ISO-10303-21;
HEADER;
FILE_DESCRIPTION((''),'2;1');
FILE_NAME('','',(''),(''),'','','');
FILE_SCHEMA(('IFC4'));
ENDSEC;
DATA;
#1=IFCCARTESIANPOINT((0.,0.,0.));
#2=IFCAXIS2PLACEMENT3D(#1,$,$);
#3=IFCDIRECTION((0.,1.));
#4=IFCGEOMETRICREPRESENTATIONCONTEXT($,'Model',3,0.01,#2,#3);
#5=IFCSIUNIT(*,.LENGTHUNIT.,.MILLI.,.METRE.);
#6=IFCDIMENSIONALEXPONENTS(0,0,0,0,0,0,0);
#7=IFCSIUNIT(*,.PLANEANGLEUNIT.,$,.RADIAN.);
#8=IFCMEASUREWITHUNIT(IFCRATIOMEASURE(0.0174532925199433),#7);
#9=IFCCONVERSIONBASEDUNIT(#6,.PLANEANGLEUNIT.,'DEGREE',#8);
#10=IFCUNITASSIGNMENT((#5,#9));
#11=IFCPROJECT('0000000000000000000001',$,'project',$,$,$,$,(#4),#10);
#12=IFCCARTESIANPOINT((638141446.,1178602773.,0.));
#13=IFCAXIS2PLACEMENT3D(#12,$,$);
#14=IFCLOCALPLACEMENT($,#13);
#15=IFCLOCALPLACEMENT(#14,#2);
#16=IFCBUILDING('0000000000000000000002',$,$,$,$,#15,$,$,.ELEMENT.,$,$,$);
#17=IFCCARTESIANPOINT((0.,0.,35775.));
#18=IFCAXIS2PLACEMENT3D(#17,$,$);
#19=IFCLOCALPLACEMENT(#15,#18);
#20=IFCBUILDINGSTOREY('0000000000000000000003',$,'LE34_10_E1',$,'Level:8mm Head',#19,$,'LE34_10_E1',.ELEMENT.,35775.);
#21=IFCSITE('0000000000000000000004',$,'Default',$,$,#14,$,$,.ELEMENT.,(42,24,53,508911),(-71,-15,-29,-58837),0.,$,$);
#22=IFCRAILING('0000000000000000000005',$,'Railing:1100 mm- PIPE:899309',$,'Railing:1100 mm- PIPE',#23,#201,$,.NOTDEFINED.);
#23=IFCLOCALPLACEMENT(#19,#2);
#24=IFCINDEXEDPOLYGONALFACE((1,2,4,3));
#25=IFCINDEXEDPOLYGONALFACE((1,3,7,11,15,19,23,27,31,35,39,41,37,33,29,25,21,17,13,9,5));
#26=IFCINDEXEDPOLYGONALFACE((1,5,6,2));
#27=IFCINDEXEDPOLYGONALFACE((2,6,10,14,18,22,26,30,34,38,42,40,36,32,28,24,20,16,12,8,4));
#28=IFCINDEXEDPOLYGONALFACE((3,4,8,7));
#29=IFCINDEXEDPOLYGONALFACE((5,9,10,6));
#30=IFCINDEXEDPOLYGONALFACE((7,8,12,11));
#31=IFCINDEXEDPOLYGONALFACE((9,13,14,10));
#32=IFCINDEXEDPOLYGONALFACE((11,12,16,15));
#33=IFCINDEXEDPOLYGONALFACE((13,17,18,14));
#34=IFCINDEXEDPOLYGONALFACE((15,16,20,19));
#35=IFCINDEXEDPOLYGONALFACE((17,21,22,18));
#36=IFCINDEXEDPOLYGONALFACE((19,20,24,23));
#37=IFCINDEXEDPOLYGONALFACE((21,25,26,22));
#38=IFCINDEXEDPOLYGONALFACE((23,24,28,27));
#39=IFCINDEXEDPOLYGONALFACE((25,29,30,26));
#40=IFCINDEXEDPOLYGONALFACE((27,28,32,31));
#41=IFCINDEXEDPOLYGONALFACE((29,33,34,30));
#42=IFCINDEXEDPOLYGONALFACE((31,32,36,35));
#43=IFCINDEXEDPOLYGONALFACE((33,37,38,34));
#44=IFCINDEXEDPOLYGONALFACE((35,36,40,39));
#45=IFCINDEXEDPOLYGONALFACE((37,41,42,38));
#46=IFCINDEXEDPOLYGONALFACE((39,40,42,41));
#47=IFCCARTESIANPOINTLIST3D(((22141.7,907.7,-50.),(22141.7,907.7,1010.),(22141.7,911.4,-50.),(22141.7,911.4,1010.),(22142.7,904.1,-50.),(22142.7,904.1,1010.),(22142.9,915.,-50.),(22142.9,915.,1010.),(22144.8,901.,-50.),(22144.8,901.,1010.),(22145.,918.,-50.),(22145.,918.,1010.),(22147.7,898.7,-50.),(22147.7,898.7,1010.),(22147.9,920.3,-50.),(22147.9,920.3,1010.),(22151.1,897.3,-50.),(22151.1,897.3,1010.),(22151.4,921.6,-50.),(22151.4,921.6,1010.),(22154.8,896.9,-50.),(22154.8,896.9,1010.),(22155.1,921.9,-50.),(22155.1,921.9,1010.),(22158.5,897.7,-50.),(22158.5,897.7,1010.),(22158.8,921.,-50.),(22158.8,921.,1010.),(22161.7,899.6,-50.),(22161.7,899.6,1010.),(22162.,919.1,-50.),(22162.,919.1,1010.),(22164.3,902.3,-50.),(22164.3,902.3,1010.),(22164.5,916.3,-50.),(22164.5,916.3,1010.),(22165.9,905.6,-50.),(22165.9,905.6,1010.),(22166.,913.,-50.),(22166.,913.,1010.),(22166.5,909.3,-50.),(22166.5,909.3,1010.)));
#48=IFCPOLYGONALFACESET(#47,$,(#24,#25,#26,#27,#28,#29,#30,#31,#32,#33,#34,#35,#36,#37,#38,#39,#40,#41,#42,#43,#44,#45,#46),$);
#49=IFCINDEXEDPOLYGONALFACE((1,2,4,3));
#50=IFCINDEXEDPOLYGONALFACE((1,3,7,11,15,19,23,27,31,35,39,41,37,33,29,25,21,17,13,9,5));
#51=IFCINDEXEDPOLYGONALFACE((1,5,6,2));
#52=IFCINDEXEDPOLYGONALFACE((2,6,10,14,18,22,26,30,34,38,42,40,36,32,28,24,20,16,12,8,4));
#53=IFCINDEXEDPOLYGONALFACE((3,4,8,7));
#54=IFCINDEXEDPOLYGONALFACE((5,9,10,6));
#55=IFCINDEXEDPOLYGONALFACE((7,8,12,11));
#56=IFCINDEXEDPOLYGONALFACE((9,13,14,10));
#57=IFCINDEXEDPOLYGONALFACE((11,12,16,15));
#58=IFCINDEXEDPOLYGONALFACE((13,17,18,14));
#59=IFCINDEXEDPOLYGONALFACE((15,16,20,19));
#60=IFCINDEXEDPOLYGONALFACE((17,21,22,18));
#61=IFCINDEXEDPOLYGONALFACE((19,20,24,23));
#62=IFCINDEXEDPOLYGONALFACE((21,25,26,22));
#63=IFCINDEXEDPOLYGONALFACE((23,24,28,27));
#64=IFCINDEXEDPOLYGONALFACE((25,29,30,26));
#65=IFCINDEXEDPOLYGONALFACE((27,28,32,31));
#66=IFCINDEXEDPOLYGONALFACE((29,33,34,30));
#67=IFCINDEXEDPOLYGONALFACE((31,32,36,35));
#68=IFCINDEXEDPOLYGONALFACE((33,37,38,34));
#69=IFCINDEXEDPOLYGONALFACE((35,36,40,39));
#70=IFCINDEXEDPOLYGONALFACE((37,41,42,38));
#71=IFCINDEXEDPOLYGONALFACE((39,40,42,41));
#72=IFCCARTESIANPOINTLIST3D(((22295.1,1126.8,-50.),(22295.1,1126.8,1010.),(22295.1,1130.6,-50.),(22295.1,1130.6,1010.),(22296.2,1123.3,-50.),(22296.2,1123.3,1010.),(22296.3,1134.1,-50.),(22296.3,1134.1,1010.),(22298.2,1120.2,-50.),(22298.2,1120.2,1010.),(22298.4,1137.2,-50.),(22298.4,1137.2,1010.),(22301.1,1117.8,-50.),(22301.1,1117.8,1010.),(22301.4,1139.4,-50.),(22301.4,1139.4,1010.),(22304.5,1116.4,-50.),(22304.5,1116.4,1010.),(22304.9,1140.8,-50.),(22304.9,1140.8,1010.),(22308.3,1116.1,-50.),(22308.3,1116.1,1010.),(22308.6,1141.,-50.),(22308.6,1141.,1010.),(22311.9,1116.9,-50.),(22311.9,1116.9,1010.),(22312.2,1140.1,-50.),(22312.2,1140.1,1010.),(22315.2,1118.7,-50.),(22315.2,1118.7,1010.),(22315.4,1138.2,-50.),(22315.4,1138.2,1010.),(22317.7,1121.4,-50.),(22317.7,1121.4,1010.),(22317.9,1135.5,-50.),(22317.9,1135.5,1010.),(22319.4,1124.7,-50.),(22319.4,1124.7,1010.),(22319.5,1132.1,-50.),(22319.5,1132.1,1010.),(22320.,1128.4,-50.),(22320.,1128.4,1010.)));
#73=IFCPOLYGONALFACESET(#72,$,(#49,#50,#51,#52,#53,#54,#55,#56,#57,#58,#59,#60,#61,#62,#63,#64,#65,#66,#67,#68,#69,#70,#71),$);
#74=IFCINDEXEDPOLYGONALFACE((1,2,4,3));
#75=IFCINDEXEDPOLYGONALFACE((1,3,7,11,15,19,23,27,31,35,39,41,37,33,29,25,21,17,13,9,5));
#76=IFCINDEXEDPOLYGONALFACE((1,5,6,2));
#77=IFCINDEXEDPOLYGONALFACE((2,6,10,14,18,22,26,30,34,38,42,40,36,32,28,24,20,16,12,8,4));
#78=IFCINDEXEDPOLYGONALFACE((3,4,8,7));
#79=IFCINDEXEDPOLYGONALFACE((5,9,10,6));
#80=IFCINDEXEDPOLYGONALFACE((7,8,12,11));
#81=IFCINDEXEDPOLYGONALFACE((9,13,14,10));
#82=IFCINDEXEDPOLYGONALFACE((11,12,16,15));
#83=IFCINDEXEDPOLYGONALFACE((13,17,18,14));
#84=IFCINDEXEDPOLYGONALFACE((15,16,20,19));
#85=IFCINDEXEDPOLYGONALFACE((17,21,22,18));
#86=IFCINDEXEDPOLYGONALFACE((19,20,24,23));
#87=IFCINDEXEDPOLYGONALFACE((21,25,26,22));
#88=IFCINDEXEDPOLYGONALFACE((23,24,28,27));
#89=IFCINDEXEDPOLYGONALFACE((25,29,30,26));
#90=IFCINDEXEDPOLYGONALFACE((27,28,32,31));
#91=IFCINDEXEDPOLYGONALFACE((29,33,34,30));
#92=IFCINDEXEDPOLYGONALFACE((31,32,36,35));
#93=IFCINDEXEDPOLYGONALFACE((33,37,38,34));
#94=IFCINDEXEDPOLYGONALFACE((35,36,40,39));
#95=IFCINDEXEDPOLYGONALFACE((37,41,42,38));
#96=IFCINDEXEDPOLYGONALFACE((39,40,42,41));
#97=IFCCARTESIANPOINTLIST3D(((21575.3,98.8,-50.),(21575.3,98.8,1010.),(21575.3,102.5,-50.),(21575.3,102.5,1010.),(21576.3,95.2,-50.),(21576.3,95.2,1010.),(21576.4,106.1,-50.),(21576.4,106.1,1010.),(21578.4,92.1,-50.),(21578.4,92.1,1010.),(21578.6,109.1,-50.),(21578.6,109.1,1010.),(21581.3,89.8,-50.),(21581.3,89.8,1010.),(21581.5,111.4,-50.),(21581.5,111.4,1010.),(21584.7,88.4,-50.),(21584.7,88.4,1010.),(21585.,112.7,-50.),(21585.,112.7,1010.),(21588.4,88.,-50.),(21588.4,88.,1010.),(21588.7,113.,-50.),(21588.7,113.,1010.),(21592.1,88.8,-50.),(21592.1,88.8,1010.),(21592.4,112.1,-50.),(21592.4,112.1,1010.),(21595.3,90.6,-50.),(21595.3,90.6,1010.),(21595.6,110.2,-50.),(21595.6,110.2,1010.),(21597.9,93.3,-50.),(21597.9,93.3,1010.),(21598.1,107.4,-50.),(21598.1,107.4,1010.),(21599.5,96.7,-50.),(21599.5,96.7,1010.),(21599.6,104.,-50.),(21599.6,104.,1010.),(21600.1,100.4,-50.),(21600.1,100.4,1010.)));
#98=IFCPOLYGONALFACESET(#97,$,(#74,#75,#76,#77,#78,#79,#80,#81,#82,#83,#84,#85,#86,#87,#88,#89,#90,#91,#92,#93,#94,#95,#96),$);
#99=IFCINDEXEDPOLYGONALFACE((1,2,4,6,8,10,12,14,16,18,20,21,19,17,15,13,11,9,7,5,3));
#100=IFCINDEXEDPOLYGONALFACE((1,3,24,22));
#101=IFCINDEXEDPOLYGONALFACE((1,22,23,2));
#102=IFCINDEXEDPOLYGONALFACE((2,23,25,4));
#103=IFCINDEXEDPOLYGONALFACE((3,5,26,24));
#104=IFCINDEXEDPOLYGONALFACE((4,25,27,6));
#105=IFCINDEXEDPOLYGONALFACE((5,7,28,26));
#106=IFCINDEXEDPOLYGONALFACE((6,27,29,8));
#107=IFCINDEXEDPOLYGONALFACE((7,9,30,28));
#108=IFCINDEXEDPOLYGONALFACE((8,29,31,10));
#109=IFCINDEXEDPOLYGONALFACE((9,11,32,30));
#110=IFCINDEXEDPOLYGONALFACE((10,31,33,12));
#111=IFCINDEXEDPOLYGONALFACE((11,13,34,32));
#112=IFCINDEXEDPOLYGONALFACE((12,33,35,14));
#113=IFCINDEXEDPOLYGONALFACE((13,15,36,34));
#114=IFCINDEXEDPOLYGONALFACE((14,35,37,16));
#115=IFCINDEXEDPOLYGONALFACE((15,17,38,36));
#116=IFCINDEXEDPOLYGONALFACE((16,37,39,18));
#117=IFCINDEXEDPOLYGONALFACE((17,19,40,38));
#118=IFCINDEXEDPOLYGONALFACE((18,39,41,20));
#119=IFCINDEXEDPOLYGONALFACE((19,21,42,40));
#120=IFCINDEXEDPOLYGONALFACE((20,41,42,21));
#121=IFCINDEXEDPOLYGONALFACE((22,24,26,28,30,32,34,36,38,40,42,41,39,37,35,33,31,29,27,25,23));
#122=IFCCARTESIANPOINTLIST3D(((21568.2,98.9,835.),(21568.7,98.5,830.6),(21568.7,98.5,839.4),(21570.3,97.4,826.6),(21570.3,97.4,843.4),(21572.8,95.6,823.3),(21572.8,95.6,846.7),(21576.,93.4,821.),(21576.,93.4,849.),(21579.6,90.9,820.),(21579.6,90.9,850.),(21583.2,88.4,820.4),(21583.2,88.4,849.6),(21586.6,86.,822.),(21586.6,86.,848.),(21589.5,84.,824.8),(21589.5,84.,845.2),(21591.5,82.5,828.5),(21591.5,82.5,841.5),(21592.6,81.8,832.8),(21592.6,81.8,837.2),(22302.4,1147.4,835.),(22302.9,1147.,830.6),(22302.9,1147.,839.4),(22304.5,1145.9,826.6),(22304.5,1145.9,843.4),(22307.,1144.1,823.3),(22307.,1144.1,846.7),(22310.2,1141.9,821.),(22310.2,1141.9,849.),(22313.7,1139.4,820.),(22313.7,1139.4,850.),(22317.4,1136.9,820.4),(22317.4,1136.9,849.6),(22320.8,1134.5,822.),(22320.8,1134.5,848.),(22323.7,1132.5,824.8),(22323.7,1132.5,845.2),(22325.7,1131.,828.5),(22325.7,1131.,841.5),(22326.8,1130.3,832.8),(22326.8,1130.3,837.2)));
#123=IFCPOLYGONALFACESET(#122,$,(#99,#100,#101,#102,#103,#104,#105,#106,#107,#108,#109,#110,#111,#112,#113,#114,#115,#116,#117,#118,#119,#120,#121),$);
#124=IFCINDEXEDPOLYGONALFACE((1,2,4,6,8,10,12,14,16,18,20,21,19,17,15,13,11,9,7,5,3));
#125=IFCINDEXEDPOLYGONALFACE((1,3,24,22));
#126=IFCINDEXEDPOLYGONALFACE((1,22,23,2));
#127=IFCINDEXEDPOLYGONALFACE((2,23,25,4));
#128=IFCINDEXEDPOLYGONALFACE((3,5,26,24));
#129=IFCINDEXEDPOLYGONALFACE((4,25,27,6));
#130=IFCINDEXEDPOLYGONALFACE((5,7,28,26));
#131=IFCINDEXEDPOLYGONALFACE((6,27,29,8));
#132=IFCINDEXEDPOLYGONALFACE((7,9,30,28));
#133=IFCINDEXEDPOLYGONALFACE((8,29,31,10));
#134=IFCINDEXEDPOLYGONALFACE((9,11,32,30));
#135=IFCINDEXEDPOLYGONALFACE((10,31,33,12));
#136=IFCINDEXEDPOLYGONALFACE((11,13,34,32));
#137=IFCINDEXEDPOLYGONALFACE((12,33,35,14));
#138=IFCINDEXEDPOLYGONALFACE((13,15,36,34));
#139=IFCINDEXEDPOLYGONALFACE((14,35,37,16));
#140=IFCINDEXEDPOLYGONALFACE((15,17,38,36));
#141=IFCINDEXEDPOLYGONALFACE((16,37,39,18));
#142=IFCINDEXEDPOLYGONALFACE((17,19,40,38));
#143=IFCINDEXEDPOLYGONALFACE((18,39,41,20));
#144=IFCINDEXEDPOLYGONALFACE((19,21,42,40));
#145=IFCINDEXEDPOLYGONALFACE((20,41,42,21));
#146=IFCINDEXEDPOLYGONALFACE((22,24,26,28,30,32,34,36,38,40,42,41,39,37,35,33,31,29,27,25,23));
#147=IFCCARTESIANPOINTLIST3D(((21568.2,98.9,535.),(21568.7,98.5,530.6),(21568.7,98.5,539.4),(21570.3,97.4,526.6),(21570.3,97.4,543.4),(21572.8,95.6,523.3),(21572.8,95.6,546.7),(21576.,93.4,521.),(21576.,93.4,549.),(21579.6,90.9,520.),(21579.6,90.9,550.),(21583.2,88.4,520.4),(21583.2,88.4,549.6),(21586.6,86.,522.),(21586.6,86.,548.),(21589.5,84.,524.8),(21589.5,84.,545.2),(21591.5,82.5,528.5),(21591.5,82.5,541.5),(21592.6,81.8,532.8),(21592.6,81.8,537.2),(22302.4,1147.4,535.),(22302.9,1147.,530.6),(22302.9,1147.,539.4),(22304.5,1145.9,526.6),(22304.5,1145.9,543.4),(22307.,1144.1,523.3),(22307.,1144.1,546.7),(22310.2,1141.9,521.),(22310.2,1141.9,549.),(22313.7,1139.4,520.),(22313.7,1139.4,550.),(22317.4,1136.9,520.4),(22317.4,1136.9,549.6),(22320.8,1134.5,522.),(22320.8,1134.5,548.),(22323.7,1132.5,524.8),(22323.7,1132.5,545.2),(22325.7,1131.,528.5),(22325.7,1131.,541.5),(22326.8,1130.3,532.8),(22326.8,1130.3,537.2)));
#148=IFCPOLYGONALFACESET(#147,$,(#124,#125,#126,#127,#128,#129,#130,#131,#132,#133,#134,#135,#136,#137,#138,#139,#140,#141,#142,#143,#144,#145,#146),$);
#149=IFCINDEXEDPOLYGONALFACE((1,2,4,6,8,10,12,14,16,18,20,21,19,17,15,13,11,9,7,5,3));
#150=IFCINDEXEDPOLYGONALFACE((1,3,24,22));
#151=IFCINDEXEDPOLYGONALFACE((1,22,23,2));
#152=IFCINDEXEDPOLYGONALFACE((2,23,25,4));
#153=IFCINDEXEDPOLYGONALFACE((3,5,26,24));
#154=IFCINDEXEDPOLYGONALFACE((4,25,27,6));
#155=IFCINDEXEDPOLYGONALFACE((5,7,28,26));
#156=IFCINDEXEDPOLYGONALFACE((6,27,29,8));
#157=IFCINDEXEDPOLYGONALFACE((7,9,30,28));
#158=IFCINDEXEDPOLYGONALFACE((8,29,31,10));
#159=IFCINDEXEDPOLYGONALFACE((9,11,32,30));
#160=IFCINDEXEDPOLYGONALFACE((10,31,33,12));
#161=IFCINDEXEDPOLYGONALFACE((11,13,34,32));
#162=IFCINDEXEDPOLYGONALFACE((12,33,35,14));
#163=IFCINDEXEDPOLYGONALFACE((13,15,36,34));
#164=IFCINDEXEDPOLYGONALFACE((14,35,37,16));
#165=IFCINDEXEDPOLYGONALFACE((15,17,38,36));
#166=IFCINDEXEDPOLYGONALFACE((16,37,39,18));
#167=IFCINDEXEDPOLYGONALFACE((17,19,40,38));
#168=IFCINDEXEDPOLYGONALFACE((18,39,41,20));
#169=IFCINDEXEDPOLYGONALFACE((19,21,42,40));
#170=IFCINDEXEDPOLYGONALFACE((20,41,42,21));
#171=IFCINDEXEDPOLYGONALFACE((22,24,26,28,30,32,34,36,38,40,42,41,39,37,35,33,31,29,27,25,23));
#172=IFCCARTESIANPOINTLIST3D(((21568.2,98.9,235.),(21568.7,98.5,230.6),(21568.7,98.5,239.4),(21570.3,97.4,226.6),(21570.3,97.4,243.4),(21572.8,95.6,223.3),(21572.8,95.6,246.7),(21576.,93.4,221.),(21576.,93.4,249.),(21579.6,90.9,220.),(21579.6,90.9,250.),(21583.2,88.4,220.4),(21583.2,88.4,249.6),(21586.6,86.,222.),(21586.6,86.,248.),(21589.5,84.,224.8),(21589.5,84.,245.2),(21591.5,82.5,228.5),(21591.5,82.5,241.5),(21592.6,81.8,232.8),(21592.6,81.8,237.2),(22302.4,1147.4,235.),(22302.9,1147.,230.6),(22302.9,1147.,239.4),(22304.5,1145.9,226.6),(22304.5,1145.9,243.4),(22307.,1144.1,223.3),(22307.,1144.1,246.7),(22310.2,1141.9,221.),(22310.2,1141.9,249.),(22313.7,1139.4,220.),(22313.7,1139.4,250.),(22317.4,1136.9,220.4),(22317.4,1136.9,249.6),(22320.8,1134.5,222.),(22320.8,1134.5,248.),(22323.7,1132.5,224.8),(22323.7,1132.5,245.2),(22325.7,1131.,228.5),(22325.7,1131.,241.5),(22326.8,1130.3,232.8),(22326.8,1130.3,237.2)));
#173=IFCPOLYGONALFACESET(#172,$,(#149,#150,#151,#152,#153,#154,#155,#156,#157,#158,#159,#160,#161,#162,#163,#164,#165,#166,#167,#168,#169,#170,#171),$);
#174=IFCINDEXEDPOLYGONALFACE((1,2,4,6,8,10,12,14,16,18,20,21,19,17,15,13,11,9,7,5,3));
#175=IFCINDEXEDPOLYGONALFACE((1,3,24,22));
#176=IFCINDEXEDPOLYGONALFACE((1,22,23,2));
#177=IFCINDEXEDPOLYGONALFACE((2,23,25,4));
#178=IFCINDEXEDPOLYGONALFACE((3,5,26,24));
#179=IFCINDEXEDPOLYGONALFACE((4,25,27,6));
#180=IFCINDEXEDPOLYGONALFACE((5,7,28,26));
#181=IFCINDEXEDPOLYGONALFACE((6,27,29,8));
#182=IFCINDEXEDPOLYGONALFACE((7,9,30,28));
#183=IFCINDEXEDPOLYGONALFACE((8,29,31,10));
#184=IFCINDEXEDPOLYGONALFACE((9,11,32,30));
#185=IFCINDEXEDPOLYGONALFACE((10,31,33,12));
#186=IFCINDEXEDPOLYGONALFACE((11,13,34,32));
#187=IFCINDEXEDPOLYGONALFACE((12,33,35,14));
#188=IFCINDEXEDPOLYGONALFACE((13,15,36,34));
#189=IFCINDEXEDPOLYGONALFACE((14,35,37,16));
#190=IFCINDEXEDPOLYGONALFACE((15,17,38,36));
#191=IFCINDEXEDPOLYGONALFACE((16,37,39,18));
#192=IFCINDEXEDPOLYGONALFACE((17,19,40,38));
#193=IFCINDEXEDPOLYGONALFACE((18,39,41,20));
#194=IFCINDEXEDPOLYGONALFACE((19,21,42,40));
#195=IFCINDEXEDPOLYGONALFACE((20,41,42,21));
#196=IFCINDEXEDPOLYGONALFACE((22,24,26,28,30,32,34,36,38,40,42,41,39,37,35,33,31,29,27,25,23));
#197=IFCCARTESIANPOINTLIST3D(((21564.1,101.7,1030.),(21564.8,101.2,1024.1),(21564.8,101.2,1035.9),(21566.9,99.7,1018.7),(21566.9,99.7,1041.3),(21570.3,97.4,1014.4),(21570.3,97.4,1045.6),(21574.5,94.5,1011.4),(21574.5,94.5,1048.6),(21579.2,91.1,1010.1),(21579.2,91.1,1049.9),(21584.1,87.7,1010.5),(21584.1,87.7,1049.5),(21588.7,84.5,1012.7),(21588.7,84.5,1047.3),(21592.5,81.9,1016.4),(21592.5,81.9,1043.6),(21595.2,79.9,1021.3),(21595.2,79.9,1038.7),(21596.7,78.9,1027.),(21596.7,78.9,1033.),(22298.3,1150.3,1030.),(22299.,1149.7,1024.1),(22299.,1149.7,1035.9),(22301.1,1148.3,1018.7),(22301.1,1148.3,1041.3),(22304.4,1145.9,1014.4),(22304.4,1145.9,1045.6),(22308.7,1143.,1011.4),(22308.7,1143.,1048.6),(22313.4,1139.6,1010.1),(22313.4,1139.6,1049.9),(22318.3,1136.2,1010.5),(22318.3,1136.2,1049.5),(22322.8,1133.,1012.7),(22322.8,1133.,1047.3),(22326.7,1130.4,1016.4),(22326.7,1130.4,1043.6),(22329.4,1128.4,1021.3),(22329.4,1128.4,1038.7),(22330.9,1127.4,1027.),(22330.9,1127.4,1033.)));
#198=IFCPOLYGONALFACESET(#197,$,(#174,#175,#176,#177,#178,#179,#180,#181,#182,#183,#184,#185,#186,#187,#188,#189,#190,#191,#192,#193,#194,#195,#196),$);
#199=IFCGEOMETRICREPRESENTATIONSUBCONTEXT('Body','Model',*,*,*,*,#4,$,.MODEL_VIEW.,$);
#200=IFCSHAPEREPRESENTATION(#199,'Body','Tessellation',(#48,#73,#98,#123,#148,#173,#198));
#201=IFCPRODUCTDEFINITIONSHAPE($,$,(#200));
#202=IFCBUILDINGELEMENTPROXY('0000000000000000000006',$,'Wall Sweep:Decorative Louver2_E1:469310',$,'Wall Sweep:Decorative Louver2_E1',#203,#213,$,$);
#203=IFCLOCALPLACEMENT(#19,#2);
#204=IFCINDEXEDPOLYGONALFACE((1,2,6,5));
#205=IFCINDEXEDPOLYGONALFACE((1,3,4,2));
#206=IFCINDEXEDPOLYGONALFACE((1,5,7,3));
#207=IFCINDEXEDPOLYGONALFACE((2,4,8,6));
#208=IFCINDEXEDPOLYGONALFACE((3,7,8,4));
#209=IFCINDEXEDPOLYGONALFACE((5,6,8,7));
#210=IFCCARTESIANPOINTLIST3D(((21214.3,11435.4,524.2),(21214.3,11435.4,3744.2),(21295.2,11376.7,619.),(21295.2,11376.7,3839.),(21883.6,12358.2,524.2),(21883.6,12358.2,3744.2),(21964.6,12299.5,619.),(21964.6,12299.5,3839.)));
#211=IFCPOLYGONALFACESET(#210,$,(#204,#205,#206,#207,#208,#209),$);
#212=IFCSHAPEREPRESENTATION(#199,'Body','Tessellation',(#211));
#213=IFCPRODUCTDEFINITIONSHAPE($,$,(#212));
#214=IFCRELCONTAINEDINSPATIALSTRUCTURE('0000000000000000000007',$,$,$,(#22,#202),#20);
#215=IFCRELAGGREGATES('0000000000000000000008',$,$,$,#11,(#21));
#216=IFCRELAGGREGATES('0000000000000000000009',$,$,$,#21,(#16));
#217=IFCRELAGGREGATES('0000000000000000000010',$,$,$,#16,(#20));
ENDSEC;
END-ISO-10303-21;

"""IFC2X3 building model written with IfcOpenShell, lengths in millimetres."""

from ifc_helpers import new_model, entity, si_unit, converted_unit, direction, frame, frame_2d, origin, place, context, subcontext, project, spatial, polyline, circle, outline, extrude, element, save


model = new_model("IFC2X3")

# Units and contexts
model_context = context("Model", 3, precision=0.01, world=origin(), true_north=direction((0.0, 1.0)))
body_context = subcontext(model_context, "Body", "Model", "MODEL_VIEW")
ifc_project = project(units=[si_unit("LENGTHUNIT", "METRE", prefix="MILLI"), converted_unit("PLANEANGLEUNIT", "DEGREE", entity("IfcRatioMeasure", 0.0174532925199433), si_unit("PLANEANGLEUNIT", "RADIAN"), dimensions=[0, 0, 0, 0, 0, 0, 0])], contexts=[model_context])

# Site, building, storey
site_placement = place(None, frame((638141446.0, 1178602773.0, 0.0)))
site = spatial("IfcSite", under=ifc_project, at=site_placement, Name="Default", CompositionType="ELEMENT", RefLatitude=(42, 24, 53, 508911), RefLongitude=(-71, -15, -29, -58837), RefElevation=0.0)
building_placement = place(site_placement, origin())
building = spatial("IfcBuilding", under=site, at=building_placement, CompositionType="ELEMENT")
storey_placement = place(building_placement, frame((0.0, 0.0, 35775.0)))
storey = spatial("IfcBuildingStorey", under=building, at=storey_placement, Name="LE34_10_E1", ObjectType="Level:8mm Head", LongName="LE34_10_E1", CompositionType="ELEMENT", Elevation=35775.0)

# Railing
railing_1_placement = place(storey_placement, origin())
element("IfcRailing", 1, at=railing_1_placement, inside=storey, Name="Railing:1100 mm- PIPE:899309", ObjectType="Railing:1100 mm- PIPE", PredefinedType="NOTDEFINED", context=body_context, shape_type="SweptSolid", body=[
    extrude(circle(Radius=12.5, at=frame_2d((0.0, 0.0), x_axis=(1.0, 0.0))), frame((22154.0, 909.4, -50.0), z_axis=(0.0, 0.0, 1.0), x_axis=(0.819152, -0.573576, 0.0)), (0.0, 0.0, 1.0), 1060.0),
    extrude(circle(Radius=12.5, at=frame_2d((0.0, 0.0), x_axis=(1.0, 0.0))), frame((22307.5, 1128.5, -50.0), z_axis=(0.0, 0.0, 1.0), x_axis=(0.819152, -0.573576, 0.0)), (0.0, 0.0, 1.0), 1060.0),
    extrude(circle(Radius=12.5, at=frame_2d((0.0, 0.0), x_axis=(1.0, 0.0))), frame((21587.6, 100.5, -50.0), z_axis=(0.0, 0.0, 1.0), x_axis=(0.819152, -0.573576, 0.0)), (0.0, 0.0, 1.0), 1060.0),
    extrude(circle(Radius=15.0, at=frame_2d((0.0, 0.0), x_axis=(1.0, 0.0))), frame((21580.5, 90.3, 835.0), z_axis=(0.573576, 0.819152, 0.0), x_axis=(-0.819152, 0.573576, 0.0)), (0.0, 0.0, 1.0), 1280.0),
    extrude(circle(Radius=15.0, at=frame_2d((0.0, 0.0), x_axis=(1.0, 0.0))), frame((21580.5, 90.3, 535.0), z_axis=(0.573576, 0.819152, 0.0), x_axis=(-0.819152, 0.573576, 0.0)), (0.0, 0.0, 1.0), 1280.0),
    extrude(circle(Radius=15.0, at=frame_2d((0.0, 0.0), x_axis=(1.0, 0.0))), frame((21580.5, 90.3, 235.0), z_axis=(0.573576, 0.819152, 0.0), x_axis=(-0.819152, 0.573576, 0.0)), (0.0, 0.0, 1.0), 1280.0),
    extrude(circle(Radius=20.0, at=frame_2d((0.0, 0.0), x_axis=(1.0, 0.0))), frame((21580.5, 90.3, 1030.0), z_axis=(0.573576, 0.819152, 0.0), x_axis=(-0.819152, 0.573576, 0.0)), (0.0, 0.0, 1.0), 1280.0),
])

# Building element proxy
proxy_1_placement = place(storey_placement, origin())
element("IfcBuildingElementProxy", 2, at=proxy_1_placement, inside=storey, Name="Wall Sweep:Decorative Louver2_E1:469310", ObjectType="Wall Sweep:Decorative Louver2_E1", context=body_context, shape_type="SweptSolid", body=[
    extrude(outline(polyline([(1038.8, -1168.4), (1176.6, -1168.4), (-1038.8, 1168.4), (-1176.6, 1168.4), (1038.8, -1168.4)])), frame((21254.7, 11406.0, 2181.6), z_axis=(0.587164, 0.809468, 0.0), x_axis=(0.58745, -0.426119, 0.687986)), (0.0, 0.0, 1.0), 1140.0),
])

save(model, "model.ifc")
